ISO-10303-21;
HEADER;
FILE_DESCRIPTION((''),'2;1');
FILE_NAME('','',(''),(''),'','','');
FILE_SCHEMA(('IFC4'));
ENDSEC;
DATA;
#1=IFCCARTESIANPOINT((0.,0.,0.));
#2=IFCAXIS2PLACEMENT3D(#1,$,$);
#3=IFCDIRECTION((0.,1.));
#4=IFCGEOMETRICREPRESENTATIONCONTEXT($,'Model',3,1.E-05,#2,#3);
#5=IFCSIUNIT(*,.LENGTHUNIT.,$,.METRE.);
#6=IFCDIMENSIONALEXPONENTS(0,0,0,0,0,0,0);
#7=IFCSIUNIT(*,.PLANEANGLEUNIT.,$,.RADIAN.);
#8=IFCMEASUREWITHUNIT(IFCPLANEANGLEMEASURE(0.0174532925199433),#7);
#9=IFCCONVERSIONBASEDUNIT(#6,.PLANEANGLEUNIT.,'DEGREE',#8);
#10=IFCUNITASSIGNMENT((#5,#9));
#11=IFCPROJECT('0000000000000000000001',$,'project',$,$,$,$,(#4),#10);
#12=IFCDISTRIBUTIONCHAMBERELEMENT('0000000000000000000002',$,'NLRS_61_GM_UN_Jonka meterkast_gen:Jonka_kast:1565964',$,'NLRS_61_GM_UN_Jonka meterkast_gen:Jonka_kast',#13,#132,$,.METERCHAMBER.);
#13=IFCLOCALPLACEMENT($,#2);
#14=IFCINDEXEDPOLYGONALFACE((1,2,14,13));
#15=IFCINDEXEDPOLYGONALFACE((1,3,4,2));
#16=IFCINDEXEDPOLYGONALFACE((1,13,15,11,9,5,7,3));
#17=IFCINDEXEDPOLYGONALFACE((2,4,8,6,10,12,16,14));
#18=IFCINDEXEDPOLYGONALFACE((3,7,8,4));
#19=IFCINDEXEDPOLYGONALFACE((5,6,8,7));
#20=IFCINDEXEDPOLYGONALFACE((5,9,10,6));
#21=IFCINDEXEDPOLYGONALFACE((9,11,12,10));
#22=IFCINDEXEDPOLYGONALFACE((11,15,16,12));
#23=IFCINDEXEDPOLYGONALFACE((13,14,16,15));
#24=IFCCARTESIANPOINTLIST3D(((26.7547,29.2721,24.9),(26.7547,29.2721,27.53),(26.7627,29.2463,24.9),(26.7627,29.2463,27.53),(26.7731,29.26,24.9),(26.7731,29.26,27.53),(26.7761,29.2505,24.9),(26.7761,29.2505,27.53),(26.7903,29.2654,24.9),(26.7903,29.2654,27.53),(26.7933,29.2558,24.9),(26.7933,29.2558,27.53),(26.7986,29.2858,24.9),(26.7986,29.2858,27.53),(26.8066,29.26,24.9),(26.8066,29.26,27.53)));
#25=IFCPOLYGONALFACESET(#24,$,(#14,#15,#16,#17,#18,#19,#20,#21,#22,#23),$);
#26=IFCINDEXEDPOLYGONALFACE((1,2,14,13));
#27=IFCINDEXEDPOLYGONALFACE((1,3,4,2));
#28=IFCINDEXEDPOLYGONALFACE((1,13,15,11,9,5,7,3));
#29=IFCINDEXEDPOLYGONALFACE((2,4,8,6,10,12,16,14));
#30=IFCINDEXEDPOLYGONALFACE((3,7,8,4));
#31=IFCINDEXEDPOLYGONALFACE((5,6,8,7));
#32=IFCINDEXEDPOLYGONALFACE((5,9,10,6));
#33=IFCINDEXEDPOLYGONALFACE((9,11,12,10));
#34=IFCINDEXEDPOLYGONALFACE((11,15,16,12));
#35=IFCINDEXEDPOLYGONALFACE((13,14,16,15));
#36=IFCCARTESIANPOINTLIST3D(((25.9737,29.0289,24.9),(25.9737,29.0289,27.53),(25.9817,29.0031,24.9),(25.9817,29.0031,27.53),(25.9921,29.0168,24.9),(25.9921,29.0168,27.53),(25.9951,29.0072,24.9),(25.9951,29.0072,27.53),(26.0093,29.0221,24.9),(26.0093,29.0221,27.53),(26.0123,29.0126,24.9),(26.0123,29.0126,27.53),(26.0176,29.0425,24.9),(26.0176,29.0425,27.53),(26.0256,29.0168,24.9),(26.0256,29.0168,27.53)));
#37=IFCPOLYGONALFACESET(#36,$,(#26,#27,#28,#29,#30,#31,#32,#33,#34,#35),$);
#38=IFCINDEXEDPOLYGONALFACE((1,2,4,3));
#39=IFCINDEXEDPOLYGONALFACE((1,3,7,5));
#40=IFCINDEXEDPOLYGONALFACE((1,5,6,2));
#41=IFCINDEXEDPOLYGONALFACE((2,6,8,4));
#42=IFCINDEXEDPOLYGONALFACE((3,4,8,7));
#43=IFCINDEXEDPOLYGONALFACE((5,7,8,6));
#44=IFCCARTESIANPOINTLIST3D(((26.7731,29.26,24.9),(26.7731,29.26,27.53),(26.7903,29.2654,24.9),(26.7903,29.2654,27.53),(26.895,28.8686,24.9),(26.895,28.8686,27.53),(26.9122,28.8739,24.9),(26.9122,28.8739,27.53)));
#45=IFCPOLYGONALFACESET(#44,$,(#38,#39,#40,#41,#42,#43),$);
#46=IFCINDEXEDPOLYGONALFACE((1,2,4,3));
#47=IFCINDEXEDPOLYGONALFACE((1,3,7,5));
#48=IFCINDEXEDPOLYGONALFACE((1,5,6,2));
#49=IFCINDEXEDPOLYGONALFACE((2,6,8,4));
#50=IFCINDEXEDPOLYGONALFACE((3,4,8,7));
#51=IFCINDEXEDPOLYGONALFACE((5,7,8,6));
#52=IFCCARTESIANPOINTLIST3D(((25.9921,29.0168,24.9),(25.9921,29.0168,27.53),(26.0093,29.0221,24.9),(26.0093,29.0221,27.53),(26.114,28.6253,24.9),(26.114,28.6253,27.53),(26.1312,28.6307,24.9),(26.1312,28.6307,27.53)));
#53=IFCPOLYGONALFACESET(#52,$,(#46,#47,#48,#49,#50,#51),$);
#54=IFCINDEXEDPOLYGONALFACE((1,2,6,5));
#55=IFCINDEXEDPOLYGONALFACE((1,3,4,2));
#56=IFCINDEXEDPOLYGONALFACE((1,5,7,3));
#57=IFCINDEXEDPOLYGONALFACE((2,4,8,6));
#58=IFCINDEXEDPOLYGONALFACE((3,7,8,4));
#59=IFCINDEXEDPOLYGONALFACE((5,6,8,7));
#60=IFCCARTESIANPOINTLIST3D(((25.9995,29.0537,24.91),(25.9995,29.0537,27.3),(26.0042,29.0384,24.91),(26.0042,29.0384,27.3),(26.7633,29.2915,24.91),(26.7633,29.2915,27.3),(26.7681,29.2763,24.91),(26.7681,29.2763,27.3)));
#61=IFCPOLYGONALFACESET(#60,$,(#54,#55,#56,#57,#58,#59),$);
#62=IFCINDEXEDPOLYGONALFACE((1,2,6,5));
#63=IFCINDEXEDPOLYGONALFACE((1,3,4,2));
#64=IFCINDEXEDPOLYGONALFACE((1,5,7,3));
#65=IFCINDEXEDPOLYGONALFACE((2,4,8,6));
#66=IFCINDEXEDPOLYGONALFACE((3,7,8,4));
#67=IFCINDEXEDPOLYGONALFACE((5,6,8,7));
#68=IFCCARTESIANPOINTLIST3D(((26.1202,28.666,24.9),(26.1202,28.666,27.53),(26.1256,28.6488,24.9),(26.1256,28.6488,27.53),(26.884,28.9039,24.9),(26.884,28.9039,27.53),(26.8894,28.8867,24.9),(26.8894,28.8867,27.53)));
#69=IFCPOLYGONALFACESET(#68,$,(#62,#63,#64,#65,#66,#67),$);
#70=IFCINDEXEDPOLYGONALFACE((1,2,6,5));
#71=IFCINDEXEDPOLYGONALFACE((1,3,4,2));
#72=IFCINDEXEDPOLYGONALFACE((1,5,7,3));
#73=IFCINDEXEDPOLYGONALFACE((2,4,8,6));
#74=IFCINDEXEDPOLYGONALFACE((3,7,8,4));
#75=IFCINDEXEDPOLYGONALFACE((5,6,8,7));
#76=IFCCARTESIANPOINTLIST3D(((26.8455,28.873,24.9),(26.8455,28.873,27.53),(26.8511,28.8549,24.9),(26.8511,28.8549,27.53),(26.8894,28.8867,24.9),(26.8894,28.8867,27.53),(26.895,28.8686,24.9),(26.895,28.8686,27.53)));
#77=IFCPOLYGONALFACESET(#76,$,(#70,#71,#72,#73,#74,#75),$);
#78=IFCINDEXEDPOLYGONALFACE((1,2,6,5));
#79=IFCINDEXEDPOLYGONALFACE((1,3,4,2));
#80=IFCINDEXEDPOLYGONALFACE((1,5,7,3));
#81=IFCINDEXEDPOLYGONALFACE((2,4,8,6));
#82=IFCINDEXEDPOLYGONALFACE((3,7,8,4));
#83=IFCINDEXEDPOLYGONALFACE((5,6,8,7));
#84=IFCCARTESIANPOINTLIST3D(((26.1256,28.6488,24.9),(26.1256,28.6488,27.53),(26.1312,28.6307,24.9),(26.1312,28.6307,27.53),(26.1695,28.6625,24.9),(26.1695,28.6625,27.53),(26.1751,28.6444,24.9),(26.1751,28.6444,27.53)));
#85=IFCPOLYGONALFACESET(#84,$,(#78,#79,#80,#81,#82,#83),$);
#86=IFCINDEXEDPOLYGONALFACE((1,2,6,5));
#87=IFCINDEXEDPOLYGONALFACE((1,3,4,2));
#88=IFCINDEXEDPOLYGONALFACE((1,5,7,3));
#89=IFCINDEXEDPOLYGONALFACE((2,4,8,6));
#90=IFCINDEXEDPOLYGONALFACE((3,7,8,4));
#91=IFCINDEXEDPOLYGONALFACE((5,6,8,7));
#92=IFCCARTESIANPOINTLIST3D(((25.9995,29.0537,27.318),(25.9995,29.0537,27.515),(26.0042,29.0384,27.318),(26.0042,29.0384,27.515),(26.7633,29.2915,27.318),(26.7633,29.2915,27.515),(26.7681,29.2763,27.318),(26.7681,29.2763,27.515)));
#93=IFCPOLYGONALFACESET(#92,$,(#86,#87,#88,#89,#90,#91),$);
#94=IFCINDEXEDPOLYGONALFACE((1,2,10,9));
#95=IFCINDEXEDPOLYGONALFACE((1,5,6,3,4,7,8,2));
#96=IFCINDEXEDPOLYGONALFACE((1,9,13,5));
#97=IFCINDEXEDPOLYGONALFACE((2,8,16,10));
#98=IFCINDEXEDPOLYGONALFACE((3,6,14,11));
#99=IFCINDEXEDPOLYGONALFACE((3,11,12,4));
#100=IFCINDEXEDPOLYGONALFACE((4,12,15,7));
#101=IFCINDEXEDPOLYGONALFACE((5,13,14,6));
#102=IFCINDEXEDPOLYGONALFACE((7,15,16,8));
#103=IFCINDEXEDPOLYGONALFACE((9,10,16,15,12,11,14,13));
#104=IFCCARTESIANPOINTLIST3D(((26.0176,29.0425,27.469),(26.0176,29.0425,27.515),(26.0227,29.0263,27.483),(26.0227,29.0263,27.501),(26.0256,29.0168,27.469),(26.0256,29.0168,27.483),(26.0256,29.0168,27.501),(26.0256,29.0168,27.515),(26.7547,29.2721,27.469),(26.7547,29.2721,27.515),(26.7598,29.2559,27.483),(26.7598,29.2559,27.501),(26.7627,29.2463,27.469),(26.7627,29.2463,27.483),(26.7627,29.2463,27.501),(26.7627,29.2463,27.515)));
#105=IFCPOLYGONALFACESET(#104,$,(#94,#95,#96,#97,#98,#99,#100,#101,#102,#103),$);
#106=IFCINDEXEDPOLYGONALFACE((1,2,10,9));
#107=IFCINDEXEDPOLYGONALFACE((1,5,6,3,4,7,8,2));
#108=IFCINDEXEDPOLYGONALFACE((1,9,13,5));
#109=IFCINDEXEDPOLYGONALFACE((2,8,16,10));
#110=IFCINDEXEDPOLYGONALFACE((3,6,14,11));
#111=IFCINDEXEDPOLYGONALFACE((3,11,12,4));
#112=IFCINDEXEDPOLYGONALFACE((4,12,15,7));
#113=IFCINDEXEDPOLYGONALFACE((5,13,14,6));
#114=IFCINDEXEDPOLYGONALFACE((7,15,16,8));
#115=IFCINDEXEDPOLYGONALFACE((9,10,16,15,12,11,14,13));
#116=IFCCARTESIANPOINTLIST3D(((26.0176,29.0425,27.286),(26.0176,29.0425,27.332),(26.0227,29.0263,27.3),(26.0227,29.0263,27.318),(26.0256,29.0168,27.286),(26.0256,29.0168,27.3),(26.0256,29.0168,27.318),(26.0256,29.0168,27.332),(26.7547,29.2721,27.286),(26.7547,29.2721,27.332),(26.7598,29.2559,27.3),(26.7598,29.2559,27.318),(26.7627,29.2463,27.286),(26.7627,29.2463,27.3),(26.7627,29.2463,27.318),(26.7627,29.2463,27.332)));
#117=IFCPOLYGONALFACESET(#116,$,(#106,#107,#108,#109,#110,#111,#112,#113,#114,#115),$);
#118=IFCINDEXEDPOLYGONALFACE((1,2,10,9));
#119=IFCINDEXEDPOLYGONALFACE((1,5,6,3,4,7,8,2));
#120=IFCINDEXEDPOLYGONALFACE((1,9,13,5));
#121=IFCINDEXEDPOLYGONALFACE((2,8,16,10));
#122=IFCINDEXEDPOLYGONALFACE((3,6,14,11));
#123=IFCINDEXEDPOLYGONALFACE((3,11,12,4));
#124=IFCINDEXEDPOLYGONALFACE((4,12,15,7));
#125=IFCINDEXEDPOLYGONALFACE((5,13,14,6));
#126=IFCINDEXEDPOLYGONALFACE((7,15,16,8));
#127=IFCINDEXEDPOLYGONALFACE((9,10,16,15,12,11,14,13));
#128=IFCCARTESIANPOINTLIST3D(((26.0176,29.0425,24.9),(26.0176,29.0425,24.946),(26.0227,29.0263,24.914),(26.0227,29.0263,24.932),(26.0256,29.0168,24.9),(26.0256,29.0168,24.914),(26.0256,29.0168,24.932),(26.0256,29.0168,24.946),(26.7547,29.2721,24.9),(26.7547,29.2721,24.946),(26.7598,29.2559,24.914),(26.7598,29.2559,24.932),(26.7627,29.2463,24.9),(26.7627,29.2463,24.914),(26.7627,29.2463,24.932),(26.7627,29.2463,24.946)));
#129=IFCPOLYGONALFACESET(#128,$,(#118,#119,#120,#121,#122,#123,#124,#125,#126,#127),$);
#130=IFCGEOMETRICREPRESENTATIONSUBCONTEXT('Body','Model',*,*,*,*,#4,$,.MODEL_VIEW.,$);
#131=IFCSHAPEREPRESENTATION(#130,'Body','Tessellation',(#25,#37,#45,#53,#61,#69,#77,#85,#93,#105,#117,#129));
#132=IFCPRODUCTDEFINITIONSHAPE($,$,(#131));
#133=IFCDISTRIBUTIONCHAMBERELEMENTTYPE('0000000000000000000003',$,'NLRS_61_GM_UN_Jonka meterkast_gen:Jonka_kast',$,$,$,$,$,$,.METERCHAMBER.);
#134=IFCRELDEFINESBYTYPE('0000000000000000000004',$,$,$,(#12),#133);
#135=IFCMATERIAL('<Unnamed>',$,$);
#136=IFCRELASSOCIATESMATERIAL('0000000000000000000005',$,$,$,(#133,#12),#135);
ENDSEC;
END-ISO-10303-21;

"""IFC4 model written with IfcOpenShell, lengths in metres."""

from ifc_helpers import new_model, entity, si_unit, converted_unit, direction, frame, origin, place, context, subcontext, project, indexed_curve, outline, extrude, source, transform, mapped, material, type_object, type_shapes, element, save


model = new_model("IFC4")

# Units and contexts
model_context = context("Model", 3, precision=1e-05, world=origin(), true_north=direction((0.0, 1.0)))
body_context = subcontext(model_context, "Body", "Model", "MODEL_VIEW")
ifc_project = project(units=[si_unit("LENGTHUNIT", "METRE"), converted_unit("PLANEANGLEUNIT", "DEGREE", entity("IfcPlaneAngleMeasure", 0.0174532925199433), si_unit("PLANEANGLEUNIT", "RADIAN"), dimensions=[0, 0, 0, 0, 0, 0, 0])], contexts=[model_context])

# Distribution chamber element
ifc_material = material(Name="<Unnamed>")
distribution_chamber_element_type = type_object("IfcDistributionChamberElementType", Name="NLRS_61_GM_UN_Jonka meterkast_gen:Jonka_kast", PredefinedType="METERCHAMBER", material=ifc_material)
shared_shape_1 = source(origin(), body_context, "Body", "SweptSolid", [
    extrude(outline(indexed_curve([(-0.0093, -0.023), (0.0178, -0.023), (0.0178, 0.023), (-0.0093, 0.023), (-0.0093, 0.009), (0.0007, 0.009), (0.0007, -0.009), (-0.0093, -0.009), (-0.0093, -0.023)], self_intersect=False)), frame((-0.409, -0.4092, 0.0), z_axis=(0.0, 0.0, 1.0), x_axis=(0.0, -1.0, 0.0)), (0.0, 0.0, 1.0), 2.63),
    extrude(outline(indexed_curve([(-0.0093, -0.023), (0.0178, -0.023), (0.0178, 0.023), (-0.0093, 0.023), (-0.0093, 0.009), (0.0007, 0.009), (0.0007, -0.009), (-0.0093, -0.009), (-0.0093, -0.023)], self_intersect=False)), frame((0.409, -0.4092, 0.0), z_axis=(0.0, 0.0, 1.0), x_axis=(0.0, -1.0, 0.0)), (0.0, 0.0, 1.0), 2.63),
    extrude(outline(indexed_curve([(-0.205, -0.009), (0.205, -0.009), (0.205, 0.009), (-0.205, 0.009), (-0.205, -0.009)], self_intersect=False)), frame((-0.409, -0.205, 0.0), z_axis=(0.0, 0.0, 1.0), x_axis=(0.0, -1.0, 0.0)), (0.0, 0.0, 1.0), 2.63),
    extrude(outline(indexed_curve([(-0.205, -0.009), (0.205, -0.009), (0.205, 0.009), (-0.205, 0.009), (-0.205, -0.009)], self_intersect=False)), frame((0.409, -0.205, 0.0), z_axis=(0.0, 0.0, 1.0), x_axis=(0.0, -1.0, 0.0)), (0.0, 0.0, 1.0), 2.63),
    extrude(outline(indexed_curve([(-0.4, -0.008), (0.4, -0.008), (0.4, 0.008), (-0.4, 0.008), (-0.4, -0.008)], self_intersect=False)), frame((0.0, -0.435, 0.01), z_axis=(0.0, 0.0, 1.0), x_axis=(-1.0, 0.0, 0.0)), (0.0, 0.0, 1.0), 2.39),
    extrude(outline(indexed_curve([(-0.4, -0.009), (0.4, -0.009), (0.4, 0.009), (-0.4, 0.009), (-0.4, -0.009)], self_intersect=False)), frame((0.0, -0.028, 0.0), z_axis=(0.0, 0.0, 1.0), x_axis=(-1.0, 0.0, 0.0)), (0.0, 0.0, 1.0), 2.63),
    extrude(outline(indexed_curve([(-0.023, -0.0095), (0.023, -0.0095), (0.023, 0.0095), (-0.023, 0.0095), (-0.023, -0.0095)], self_intersect=False)), frame((-0.377, -0.0095, 0.0), z_axis=(0.0, 0.0, 1.0), x_axis=(-1.0, 0.0, 0.0)), (0.0, 0.0, 1.0), 2.63),
    extrude(outline(indexed_curve([(-0.023, -0.0095), (0.023, -0.0095), (0.023, 0.0095), (-0.023, 0.0095), (-0.023, -0.0095)], self_intersect=False)), frame((0.377, -0.0095, 0.0), z_axis=(0.0, 0.0, 1.0), x_axis=(-1.0, 0.0, 0.0)), (0.0, 0.0, 1.0), 2.63),
    extrude(outline(indexed_curve([(-0.4, -0.008), (0.4, -0.008), (0.4, 0.008), (-0.4, 0.008), (-0.4, -0.008)], self_intersect=False)), frame((0.0, -0.435, 2.418), z_axis=(0.0, 0.0, 1.0), x_axis=(-1.0, 0.0, 0.0)), (0.0, 0.0, 1.0), 0.197),
    extrude(outline(indexed_curve([(-0.023, -0.0178), (0.023, -0.0178), (0.023, 0.0093), (0.009, 0.0093), (0.009, -0.0007), (-0.009, -0.0007), (-0.009, 0.0093), (-0.023, 0.0093), (-0.023, -0.0178)], self_intersect=False)), frame((-0.386, -0.4092, 2.592), z_axis=(1.0, 0.0, 0.0), x_axis=(0.0, 0.0, -1.0)), (0.0, 0.0, 1.0), 0.772),
    extrude(outline(indexed_curve([(-0.023, -0.0178), (0.023, -0.0178), (0.023, 0.0093), (0.009, 0.0093), (0.009, -0.0007), (-0.009, -0.0007), (-0.009, 0.0093), (-0.023, 0.0093), (-0.023, -0.0178)], self_intersect=False)), frame((-0.386, -0.4092, 2.409), z_axis=(1.0, 0.0, 0.0), x_axis=(0.0, 0.0, -1.0)), (0.0, 0.0, 1.0), 0.772),
    extrude(outline(indexed_curve([(-0.023, -0.0178), (0.023, -0.0178), (0.023, 0.0093), (0.009, 0.0093), (0.009, -0.0007), (-0.009, -0.0007), (-0.009, 0.0093), (-0.023, 0.0093), (-0.023, -0.0178)], self_intersect=False)), frame((-0.386, -0.4092, 0.023), z_axis=(1.0, 0.0, 0.0), x_axis=(0.0, 0.0, -1.0)), (0.0, 0.0, 1.0), 0.772),
])
type_shapes(distribution_chamber_element_type, [shared_shape_1])
placement_1 = place(None, frame((13.1348, 11.9886, 0.0), z_axis=(0.0, 0.0, 1.0), x_axis=(0.954771, 0.297342, 0.0)))
placement_2 = place(placement_1, origin())
placement_3 = place(placement_2, frame((0.0, 0.0, 24.9)))
placement_4 = place(placement_3, origin())
distribution_chamber_element_1_placement = place(placement_4, frame((17.757, 12.025, 0.0), z_axis=(0.0, 0.0, 1.0), x_axis=(-1.0, 0.0, 0.0)))
element("IfcDistributionChamberElement", 1, at=distribution_chamber_element_1_placement, type_object=distribution_chamber_element_type, material=ifc_material, Name="NLRS_61_GM_UN_Jonka meterkast_gen:Jonka_kast:1565964", ObjectType="NLRS_61_GM_UN_Jonka meterkast_gen:Jonka_kast", PredefinedType="METERCHAMBER", context=body_context, shape_type="MappedRepresentation", body=[
    mapped(shared_shape_1, transform((0.0, 0.0, 0.0), scale=1.0)),
])

save(model, "model.ifc")
